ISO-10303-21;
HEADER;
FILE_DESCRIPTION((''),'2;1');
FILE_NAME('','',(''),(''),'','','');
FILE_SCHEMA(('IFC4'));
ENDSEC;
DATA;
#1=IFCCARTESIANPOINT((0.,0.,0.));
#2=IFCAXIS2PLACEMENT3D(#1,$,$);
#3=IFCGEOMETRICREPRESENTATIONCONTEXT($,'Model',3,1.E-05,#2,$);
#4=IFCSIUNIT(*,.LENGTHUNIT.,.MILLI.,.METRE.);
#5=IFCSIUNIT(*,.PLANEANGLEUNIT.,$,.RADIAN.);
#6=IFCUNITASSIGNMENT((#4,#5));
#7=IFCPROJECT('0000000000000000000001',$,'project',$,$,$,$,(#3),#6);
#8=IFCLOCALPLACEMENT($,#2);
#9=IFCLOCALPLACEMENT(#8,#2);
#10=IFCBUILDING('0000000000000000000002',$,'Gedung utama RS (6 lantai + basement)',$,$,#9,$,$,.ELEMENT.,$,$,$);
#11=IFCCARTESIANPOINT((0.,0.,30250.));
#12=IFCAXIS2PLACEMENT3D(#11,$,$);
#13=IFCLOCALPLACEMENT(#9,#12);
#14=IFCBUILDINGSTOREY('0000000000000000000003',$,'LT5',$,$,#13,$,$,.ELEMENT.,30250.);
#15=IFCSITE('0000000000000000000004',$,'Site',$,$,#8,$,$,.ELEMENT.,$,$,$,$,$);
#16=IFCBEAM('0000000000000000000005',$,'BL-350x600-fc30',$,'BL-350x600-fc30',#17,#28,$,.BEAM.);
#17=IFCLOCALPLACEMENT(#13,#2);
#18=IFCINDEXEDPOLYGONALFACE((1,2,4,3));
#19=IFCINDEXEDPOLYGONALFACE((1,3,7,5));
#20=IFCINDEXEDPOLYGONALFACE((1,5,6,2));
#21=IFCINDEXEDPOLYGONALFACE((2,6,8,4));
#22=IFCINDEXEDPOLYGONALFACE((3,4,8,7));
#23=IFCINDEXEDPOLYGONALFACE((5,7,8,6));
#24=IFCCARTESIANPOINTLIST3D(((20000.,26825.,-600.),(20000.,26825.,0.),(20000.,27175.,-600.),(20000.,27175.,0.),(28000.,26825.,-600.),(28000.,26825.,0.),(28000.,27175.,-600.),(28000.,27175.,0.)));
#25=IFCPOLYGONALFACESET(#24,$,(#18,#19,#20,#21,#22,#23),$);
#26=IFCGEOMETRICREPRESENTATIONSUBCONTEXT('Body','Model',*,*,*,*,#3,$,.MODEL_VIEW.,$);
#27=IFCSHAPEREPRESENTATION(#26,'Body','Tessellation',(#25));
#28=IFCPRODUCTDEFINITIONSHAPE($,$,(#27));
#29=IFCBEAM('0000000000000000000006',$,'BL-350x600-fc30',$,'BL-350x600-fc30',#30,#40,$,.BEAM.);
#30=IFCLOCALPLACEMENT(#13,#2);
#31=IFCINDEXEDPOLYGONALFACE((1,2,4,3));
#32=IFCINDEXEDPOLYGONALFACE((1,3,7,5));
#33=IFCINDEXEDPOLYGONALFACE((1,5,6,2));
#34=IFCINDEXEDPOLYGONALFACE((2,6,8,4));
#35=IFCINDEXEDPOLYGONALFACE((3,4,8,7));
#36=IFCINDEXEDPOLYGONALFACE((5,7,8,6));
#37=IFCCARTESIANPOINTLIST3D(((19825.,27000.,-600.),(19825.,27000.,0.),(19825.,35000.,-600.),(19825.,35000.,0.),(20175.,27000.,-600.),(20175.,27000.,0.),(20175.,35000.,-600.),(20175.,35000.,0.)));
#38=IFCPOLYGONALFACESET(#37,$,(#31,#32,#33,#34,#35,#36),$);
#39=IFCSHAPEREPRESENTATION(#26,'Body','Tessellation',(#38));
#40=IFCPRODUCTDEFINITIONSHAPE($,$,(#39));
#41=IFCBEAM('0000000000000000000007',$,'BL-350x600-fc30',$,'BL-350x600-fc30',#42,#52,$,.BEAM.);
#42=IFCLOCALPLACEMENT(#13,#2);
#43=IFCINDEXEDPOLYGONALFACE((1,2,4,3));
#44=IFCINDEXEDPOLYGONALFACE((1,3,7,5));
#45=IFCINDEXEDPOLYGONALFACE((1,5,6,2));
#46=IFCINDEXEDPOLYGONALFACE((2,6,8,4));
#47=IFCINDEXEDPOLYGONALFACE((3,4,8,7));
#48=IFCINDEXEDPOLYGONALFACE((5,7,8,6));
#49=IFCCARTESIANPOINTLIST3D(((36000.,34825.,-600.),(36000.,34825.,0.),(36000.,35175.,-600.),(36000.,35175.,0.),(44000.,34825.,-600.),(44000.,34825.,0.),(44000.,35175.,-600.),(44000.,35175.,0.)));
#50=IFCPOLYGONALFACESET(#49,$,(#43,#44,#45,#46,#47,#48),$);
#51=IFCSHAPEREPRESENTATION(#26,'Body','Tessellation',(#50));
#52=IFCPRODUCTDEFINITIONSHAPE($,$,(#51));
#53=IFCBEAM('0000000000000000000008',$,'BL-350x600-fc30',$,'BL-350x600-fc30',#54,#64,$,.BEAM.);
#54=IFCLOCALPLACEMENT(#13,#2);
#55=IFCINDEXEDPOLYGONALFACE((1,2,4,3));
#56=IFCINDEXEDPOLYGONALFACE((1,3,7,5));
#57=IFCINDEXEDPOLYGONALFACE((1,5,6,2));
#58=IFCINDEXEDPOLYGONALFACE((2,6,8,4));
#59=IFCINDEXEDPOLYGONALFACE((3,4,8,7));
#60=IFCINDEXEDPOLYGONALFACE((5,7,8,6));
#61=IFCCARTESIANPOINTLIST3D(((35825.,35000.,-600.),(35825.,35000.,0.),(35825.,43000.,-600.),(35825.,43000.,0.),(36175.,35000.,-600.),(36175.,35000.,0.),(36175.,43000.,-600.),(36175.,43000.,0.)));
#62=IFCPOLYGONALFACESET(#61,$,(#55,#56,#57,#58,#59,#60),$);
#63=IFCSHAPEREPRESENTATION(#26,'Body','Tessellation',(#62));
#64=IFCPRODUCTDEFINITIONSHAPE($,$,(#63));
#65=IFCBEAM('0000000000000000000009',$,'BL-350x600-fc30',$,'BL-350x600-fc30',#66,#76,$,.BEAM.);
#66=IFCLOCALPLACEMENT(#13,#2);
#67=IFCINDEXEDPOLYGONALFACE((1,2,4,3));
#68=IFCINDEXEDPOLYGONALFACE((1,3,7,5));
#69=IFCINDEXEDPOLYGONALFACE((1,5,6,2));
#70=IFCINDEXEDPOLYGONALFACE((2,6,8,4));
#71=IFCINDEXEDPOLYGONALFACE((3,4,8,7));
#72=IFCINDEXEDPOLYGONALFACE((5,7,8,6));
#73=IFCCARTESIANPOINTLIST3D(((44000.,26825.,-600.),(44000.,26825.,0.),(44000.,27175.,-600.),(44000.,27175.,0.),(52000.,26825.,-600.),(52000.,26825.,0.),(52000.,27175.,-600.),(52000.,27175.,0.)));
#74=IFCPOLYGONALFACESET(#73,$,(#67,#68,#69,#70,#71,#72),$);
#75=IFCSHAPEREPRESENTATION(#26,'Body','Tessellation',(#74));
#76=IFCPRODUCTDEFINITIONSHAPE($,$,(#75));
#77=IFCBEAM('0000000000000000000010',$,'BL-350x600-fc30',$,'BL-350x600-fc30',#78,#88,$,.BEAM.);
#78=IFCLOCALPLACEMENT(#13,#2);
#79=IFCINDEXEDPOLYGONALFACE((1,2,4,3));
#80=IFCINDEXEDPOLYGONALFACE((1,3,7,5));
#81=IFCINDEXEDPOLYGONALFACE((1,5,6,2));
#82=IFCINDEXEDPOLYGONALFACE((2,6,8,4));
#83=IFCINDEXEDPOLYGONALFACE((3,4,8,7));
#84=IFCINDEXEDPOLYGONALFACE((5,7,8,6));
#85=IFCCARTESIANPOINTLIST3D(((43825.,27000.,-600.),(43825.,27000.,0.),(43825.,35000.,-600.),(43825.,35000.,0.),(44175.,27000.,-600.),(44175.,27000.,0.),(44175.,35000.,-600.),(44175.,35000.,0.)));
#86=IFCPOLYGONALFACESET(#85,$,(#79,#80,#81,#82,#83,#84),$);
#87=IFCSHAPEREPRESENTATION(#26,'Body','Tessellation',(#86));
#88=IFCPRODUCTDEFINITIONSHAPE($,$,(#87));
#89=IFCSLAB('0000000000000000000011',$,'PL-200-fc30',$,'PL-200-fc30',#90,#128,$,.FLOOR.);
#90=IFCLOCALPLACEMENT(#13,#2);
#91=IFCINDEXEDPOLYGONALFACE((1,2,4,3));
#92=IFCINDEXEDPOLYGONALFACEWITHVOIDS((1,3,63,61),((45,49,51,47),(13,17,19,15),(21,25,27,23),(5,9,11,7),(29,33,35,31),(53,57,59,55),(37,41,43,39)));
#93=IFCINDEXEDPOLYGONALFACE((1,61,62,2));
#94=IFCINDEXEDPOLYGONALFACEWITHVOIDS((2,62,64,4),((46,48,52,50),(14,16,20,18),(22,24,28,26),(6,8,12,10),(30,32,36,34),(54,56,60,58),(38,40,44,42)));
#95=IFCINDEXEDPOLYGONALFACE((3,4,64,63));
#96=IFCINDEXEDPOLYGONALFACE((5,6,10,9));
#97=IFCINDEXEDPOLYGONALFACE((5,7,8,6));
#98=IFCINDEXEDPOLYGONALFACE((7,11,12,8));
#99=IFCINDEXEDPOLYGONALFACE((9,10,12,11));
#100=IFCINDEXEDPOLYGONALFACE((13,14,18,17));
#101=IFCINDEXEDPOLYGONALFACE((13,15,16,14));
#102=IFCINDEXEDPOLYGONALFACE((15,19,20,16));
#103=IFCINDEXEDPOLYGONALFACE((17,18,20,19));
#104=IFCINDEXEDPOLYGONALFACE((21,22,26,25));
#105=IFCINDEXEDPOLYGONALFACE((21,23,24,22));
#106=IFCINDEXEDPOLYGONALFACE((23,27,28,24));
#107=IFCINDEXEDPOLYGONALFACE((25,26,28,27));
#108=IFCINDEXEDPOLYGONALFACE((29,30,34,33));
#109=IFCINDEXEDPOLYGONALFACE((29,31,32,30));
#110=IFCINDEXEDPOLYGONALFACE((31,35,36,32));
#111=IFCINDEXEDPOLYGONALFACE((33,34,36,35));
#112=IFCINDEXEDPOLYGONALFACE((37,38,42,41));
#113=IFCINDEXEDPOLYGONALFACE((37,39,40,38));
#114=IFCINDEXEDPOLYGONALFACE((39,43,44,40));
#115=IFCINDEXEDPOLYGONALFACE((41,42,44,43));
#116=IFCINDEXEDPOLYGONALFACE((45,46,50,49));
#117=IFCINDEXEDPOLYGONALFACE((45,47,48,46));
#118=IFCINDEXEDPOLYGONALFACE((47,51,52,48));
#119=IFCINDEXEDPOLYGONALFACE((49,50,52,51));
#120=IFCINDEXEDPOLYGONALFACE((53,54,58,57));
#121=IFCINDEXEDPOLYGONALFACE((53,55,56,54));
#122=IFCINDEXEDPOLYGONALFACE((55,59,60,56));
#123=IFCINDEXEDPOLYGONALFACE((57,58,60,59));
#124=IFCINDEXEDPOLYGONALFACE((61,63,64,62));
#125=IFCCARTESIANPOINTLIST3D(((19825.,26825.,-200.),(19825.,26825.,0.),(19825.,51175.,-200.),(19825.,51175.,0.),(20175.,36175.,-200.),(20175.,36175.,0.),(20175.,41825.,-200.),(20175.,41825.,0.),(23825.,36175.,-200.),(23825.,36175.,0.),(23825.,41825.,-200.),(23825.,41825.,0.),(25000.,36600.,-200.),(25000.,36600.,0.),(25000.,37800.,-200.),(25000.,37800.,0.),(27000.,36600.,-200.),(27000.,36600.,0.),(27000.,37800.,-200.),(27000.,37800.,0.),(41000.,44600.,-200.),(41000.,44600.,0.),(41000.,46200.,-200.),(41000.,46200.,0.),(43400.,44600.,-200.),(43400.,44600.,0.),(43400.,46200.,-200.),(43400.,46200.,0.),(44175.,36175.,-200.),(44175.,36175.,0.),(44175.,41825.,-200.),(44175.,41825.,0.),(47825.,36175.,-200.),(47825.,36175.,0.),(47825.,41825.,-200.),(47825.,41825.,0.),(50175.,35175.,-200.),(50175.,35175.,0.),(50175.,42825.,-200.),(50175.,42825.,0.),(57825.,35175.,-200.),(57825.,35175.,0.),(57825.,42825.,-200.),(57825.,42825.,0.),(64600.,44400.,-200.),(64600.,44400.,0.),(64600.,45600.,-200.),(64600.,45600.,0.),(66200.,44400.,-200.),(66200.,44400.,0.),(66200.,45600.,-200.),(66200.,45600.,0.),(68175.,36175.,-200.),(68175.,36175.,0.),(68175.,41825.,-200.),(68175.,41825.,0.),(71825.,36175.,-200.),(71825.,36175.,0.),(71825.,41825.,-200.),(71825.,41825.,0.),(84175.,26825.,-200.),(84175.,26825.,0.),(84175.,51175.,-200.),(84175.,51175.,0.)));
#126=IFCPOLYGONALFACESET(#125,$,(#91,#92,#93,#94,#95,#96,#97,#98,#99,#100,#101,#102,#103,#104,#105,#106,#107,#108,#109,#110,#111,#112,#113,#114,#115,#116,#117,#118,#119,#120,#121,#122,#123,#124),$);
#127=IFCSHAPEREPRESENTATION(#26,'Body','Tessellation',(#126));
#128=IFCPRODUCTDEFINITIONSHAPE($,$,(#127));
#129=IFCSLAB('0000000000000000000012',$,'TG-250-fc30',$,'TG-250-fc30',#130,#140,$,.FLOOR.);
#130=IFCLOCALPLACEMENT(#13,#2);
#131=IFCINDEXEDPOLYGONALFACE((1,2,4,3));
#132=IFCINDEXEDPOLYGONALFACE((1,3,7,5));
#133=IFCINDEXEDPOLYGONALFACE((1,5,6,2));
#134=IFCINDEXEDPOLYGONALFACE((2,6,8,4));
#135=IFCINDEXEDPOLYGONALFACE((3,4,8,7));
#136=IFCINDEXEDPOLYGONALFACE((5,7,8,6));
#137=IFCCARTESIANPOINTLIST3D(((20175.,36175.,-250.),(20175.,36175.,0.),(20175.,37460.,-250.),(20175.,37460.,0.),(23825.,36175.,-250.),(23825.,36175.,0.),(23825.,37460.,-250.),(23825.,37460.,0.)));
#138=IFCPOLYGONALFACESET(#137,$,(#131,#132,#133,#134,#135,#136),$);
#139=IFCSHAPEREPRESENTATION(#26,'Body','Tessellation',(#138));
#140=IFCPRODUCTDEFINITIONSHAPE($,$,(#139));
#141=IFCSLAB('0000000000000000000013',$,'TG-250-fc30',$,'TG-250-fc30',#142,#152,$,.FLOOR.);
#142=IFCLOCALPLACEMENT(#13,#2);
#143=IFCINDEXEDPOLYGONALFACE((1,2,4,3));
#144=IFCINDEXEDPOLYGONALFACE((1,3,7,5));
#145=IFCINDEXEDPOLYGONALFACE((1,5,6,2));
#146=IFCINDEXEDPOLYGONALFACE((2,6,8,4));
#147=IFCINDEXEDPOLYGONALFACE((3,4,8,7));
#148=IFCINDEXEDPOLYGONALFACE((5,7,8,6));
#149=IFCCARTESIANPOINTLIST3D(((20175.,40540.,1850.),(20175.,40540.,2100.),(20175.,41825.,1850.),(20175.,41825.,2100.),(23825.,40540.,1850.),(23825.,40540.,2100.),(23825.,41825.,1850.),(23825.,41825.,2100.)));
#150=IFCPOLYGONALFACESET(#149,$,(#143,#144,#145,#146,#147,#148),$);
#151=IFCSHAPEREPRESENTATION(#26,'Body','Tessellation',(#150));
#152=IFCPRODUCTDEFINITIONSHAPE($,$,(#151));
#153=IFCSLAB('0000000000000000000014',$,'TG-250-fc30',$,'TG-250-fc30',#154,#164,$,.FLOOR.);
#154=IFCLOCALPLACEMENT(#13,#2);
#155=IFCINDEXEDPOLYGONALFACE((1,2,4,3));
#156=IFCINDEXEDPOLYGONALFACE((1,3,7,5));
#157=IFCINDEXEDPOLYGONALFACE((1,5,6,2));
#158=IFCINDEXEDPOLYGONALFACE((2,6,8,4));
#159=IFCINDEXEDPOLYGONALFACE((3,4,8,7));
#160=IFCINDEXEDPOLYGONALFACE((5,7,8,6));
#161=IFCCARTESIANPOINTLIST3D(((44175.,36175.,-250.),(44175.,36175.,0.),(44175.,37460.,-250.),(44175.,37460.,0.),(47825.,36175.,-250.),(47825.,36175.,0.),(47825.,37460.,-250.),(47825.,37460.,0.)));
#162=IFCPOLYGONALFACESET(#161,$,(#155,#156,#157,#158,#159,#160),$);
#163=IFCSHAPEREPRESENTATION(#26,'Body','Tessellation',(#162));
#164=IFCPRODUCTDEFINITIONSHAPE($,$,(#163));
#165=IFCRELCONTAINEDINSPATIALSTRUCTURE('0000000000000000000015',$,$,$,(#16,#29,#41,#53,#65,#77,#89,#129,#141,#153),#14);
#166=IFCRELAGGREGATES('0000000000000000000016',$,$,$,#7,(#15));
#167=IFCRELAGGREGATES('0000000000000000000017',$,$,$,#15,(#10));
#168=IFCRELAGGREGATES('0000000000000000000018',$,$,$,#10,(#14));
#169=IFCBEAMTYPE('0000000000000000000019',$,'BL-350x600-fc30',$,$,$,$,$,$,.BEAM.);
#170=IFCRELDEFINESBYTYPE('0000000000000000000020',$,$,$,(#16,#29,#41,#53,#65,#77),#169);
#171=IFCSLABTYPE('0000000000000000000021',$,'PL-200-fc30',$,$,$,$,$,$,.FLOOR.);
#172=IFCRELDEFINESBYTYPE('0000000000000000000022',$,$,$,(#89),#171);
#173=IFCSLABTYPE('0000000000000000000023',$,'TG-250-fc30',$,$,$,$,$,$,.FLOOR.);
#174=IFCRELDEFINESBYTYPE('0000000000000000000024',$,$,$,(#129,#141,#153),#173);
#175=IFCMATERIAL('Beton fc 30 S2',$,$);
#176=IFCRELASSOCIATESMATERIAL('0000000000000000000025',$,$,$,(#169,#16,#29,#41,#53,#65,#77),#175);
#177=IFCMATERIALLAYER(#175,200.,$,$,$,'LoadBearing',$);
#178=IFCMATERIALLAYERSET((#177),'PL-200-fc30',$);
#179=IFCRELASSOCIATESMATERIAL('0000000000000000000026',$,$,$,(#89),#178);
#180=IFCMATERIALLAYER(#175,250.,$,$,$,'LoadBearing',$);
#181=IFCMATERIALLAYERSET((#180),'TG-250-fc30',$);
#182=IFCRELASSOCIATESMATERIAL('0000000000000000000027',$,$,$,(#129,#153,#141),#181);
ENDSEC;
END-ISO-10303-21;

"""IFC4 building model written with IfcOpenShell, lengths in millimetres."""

from ifc_helpers import new_model, si_unit, frame, origin, origin_2d, place, context, subcontext, project, spatial, polyline, rectangle, outline, extrude, material, layer, layer_set, layer_usage, material_profile, profile_set, profile_usage, type_object, element, save


model = new_model("IFC4")

# Units and contexts
model_context = context("Model", 3, precision=1e-05, world=origin())
body_context = subcontext(model_context, "Body", "Model", "MODEL_VIEW")
ifc_project = project(units=[si_unit("LENGTHUNIT", "METRE", prefix="MILLI"), si_unit("PLANEANGLEUNIT", "RADIAN")], contexts=[model_context])

# Site, building, storey
site_placement = place(None, origin())
site = spatial("IfcSite", under=ifc_project, at=site_placement, Name="Site", CompositionType="ELEMENT")
building_placement = place(site_placement, origin())
building = spatial("IfcBuilding", under=site, at=building_placement, Name="Gedung utama RS (6 lantai + basement)", CompositionType="ELEMENT")
storey_placement = place(building_placement, frame((0.0, 0.0, 30250.0)))
storey = spatial("IfcBuildingStorey", under=building, at=storey_placement, Name="LT5", CompositionType="ELEMENT", Elevation=30250.0)

# Beams
ifc_material = material(Name="Beton fc 30 S2")
ifc_material_profile_1 = material_profile(ifc_material, rectangle(XDim=350.0, YDim=600.0, at=origin_2d()), Name="BL-350x600-fc30")
ifc_profile_set_1 = profile_set([ifc_material_profile_1], Name="BL-350x600-fc30")
ifc_profile_usage_1 = profile_usage(ifc_profile_set_1, cardinal=8)
beam_type = type_object("IfcBeamType", Name="BL-350x600-fc30", PredefinedType="BEAM", material=ifc_profile_set_1)
beam_1_placement = place(storey_placement, frame((20000.0, 27000.0, -300.0)))
element("IfcBeam", 1, at=beam_1_placement, inside=storey, type_object=beam_type, material=ifc_profile_usage_1, Name="BL-350x600-fc30", ObjectType="BL-350x600-fc30", PredefinedType="BEAM", context=body_context, shape_type="SweptSolid", body=[
    extrude(rectangle(XDim=350.0, YDim=600.0, at=origin_2d()), frame((0.0, 0.0, 0.0), z_axis=(1.0, 0.0, 0.0), x_axis=(0.0, 1.0, 0.0)), (0.0, 0.0, 1.0), 8000.0),
])
beam_2_placement = place(storey_placement, frame((20000.0, 27000.0, -300.0)))
element("IfcBeam", 2, at=beam_2_placement, inside=storey, type_object=beam_type, material=ifc_profile_usage_1, Name="BL-350x600-fc30", ObjectType="BL-350x600-fc30", PredefinedType="BEAM", context=body_context, shape_type="SweptSolid", body=[
    extrude(rectangle(XDim=350.0, YDim=600.0, at=origin_2d()), frame((0.0, 0.0, 0.0), z_axis=(0.0, 1.0, 0.0), x_axis=(-1.0, 0.0, 0.0)), (0.0, 0.0, 1.0), 8000.0),
])
beam_3_placement = place(storey_placement, frame((36000.0, 35000.0, -300.0)))
element("IfcBeam", 3, at=beam_3_placement, inside=storey, type_object=beam_type, material=ifc_profile_usage_1, Name="BL-350x600-fc30", ObjectType="BL-350x600-fc30", PredefinedType="BEAM", context=body_context, shape_type="SweptSolid", body=[
    extrude(rectangle(XDim=350.0, YDim=600.0, at=origin_2d()), frame((0.0, 0.0, 0.0), z_axis=(1.0, 0.0, 0.0), x_axis=(0.0, 1.0, 0.0)), (0.0, 0.0, 1.0), 8000.0),
])
beam_4_placement = place(storey_placement, frame((36000.0, 35000.0, -300.0)))
element("IfcBeam", 4, at=beam_4_placement, inside=storey, type_object=beam_type, material=ifc_profile_usage_1, Name="BL-350x600-fc30", ObjectType="BL-350x600-fc30", PredefinedType="BEAM", context=body_context, shape_type="SweptSolid", body=[
    extrude(rectangle(XDim=350.0, YDim=600.0, at=origin_2d()), frame((0.0, 0.0, 0.0), z_axis=(0.0, 1.0, 0.0), x_axis=(-1.0, 0.0, 0.0)), (0.0, 0.0, 1.0), 8000.0),
])
beam_5_placement = place(storey_placement, frame((44000.0, 27000.0, -300.0)))
element("IfcBeam", 5, at=beam_5_placement, inside=storey, type_object=beam_type, material=ifc_profile_usage_1, Name="BL-350x600-fc30", ObjectType="BL-350x600-fc30", PredefinedType="BEAM", context=body_context, shape_type="SweptSolid", body=[
    extrude(rectangle(XDim=350.0, YDim=600.0, at=origin_2d()), frame((0.0, 0.0, 0.0), z_axis=(1.0, 0.0, 0.0), x_axis=(0.0, 1.0, 0.0)), (0.0, 0.0, 1.0), 8000.0),
])
beam_6_placement = place(storey_placement, frame((44000.0, 27000.0, -300.0)))
element("IfcBeam", 6, at=beam_6_placement, inside=storey, type_object=beam_type, material=ifc_profile_usage_1, Name="BL-350x600-fc30", ObjectType="BL-350x600-fc30", PredefinedType="BEAM", context=body_context, shape_type="SweptSolid", body=[
    extrude(rectangle(XDim=350.0, YDim=600.0, at=origin_2d()), frame((0.0, 0.0, 0.0), z_axis=(0.0, 1.0, 0.0), x_axis=(-1.0, 0.0, 0.0)), (0.0, 0.0, 1.0), 8000.0),
])

# Slab, openings
ifc_layer_1 = layer(ifc_material, 200.0, Category="LoadBearing")
ifc_layer_set_1 = layer_set([ifc_layer_1], Name="PL-200-fc30")
ifc_layer_usage_1 = layer_usage(ifc_layer_set_1, "AXIS3", "NEGATIVE", 0.0)
slab_type_1 = type_object("IfcSlabType", Name="PL-200-fc30", PredefinedType="FLOOR")
slab_1_placement = place(storey_placement, origin())
slab_1 = element("IfcSlab", 7, at=slab_1_placement, inside=storey, type_object=slab_type_1, material=ifc_layer_usage_1, Name="PL-200-fc30", ObjectType="PL-200-fc30", PredefinedType="FLOOR", context=body_context, shape_type="SweptSolid", body=[
    extrude(outline(polyline([(84175.0, 51175.0), (19825.0, 51175.0), (19825.0, 26825.0), (84175.0, 26825.0), (84175.0, 51175.0)]), holes=[polyline([(23825.0, 36175.0), (23825.0, 41825.0), (20175.0, 41825.0), (20175.0, 36175.0), (23825.0, 36175.0)]), polyline([(47825.0, 36175.0), (47825.0, 41825.0), (44175.0, 41825.0), (44175.0, 36175.0), (47825.0, 36175.0)]), polyline([(71825.0, 36175.0), (71825.0, 41825.0), (68175.0, 41825.0), (68175.0, 36175.0), (71825.0, 36175.0)])]), frame((0.0, 0.0, -200.0)), (0.0, 0.0, 1.0), 200.0),
])
opening_1_placement = place(slab_1_placement, frame((0.0, 0.0, -17300.0)))
element("IfcOpeningElement", 8, at=opening_1_placement, cuts=slab_1, PredefinedType="OPENING", context=body_context, shape_type="SweptSolid", body=[
    extrude(outline(polyline([(27000.0, 36600.0), (27000.0, 37800.0), (25000.0, 37800.0), (25000.0, 36600.0), (27000.0, 36600.0)])), origin(), (0.0, 0.0, 1.0), 25800.0),
])
opening_2_placement = place(slab_1_placement, frame((0.0, 0.0, -17300.0)))
element("IfcOpeningElement", 9, at=opening_2_placement, cuts=slab_1, PredefinedType="OPENING", context=body_context, shape_type="SweptSolid", body=[
    extrude(outline(polyline([(43400.0, 44600.0), (43400.0, 46200.0), (41000.0, 46200.0), (41000.0, 44600.0), (43400.0, 44600.0)])), origin(), (0.0, 0.0, 1.0), 25800.0),
])
opening_3_placement = place(slab_1_placement, frame((0.0, 0.0, -17300.0)))
element("IfcOpeningElement", 10, at=opening_3_placement, cuts=slab_1, PredefinedType="OPENING", context=body_context, shape_type="SweptSolid", body=[
    extrude(outline(polyline([(66200.0, 44400.0), (66200.0, 45600.0), (64600.0, 45600.0), (64600.0, 44400.0), (66200.0, 44400.0)])), origin(), (0.0, 0.0, 1.0), 25800.0),
])
opening_4_placement = place(slab_1_placement, frame((0.0, 0.0, -17300.0)))
element("IfcOpeningElement", 11, at=opening_4_placement, cuts=slab_1, PredefinedType="OPENING", context=body_context, shape_type="SweptSolid", body=[
    extrude(outline(polyline([(57825.0, 35175.0), (57825.0, 42825.0), (50175.0, 42825.0), (50175.0, 35175.0), (57825.0, 35175.0)])), origin(), (0.0, 0.0, 1.0), 21600.0),
])

# Slabs
ifc_layer_2 = layer(ifc_material, 250.0, Category="LoadBearing")
ifc_layer_set_2 = layer_set([ifc_layer_2], Name="TG-250-fc30")
ifc_layer_usage_2 = layer_usage(ifc_layer_set_2, "AXIS3", "NEGATIVE", 0.0)
slab_type_2 = type_object("IfcSlabType", Name="TG-250-fc30", PredefinedType="FLOOR")
slab_2_placement = place(storey_placement, origin())
element("IfcSlab", 12, at=slab_2_placement, inside=storey, type_object=slab_type_2, material=ifc_layer_usage_2, Name="TG-250-fc30", ObjectType="TG-250-fc30", PredefinedType="FLOOR", context=body_context, shape_type="SweptSolid", body=[
    extrude(outline(polyline([(23825.0, 36175.0), (23825.0, 37460.0), (20175.0, 37460.0), (20175.0, 36175.0), (23825.0, 36175.0)])), frame((0.0, 0.0, -250.0)), (0.0, 0.0, 1.0), 250.0),
])
ifc_layer_usage_3 = layer_usage(ifc_layer_set_2, "AXIS3", "NEGATIVE", 2100.0)
slab_3_placement = place(storey_placement, origin())
element("IfcSlab", 13, at=slab_3_placement, inside=storey, type_object=slab_type_2, material=ifc_layer_usage_3, Name="TG-250-fc30", ObjectType="TG-250-fc30", PredefinedType="FLOOR", context=body_context, shape_type="SweptSolid", body=[
    extrude(outline(polyline([(23825.0, 40540.0), (23825.0, 41825.0), (20175.0, 41825.0), (20175.0, 40540.0), (23825.0, 40540.0)])), frame((0.0, 0.0, 1850.0)), (0.0, 0.0, 1.0), 250.0),
])
slab_4_placement = place(storey_placement, origin())
element("IfcSlab", 14, at=slab_4_placement, inside=storey, type_object=slab_type_2, material=ifc_layer_usage_2, Name="TG-250-fc30", ObjectType="TG-250-fc30", PredefinedType="FLOOR", context=body_context, shape_type="SweptSolid", body=[
    extrude(outline(polyline([(47825.0, 36175.0), (47825.0, 37460.0), (44175.0, 37460.0), (44175.0, 36175.0), (47825.0, 36175.0)])), frame((0.0, 0.0, -250.0)), (0.0, 0.0, 1.0), 250.0),
])

save(model, "model.ifc")
